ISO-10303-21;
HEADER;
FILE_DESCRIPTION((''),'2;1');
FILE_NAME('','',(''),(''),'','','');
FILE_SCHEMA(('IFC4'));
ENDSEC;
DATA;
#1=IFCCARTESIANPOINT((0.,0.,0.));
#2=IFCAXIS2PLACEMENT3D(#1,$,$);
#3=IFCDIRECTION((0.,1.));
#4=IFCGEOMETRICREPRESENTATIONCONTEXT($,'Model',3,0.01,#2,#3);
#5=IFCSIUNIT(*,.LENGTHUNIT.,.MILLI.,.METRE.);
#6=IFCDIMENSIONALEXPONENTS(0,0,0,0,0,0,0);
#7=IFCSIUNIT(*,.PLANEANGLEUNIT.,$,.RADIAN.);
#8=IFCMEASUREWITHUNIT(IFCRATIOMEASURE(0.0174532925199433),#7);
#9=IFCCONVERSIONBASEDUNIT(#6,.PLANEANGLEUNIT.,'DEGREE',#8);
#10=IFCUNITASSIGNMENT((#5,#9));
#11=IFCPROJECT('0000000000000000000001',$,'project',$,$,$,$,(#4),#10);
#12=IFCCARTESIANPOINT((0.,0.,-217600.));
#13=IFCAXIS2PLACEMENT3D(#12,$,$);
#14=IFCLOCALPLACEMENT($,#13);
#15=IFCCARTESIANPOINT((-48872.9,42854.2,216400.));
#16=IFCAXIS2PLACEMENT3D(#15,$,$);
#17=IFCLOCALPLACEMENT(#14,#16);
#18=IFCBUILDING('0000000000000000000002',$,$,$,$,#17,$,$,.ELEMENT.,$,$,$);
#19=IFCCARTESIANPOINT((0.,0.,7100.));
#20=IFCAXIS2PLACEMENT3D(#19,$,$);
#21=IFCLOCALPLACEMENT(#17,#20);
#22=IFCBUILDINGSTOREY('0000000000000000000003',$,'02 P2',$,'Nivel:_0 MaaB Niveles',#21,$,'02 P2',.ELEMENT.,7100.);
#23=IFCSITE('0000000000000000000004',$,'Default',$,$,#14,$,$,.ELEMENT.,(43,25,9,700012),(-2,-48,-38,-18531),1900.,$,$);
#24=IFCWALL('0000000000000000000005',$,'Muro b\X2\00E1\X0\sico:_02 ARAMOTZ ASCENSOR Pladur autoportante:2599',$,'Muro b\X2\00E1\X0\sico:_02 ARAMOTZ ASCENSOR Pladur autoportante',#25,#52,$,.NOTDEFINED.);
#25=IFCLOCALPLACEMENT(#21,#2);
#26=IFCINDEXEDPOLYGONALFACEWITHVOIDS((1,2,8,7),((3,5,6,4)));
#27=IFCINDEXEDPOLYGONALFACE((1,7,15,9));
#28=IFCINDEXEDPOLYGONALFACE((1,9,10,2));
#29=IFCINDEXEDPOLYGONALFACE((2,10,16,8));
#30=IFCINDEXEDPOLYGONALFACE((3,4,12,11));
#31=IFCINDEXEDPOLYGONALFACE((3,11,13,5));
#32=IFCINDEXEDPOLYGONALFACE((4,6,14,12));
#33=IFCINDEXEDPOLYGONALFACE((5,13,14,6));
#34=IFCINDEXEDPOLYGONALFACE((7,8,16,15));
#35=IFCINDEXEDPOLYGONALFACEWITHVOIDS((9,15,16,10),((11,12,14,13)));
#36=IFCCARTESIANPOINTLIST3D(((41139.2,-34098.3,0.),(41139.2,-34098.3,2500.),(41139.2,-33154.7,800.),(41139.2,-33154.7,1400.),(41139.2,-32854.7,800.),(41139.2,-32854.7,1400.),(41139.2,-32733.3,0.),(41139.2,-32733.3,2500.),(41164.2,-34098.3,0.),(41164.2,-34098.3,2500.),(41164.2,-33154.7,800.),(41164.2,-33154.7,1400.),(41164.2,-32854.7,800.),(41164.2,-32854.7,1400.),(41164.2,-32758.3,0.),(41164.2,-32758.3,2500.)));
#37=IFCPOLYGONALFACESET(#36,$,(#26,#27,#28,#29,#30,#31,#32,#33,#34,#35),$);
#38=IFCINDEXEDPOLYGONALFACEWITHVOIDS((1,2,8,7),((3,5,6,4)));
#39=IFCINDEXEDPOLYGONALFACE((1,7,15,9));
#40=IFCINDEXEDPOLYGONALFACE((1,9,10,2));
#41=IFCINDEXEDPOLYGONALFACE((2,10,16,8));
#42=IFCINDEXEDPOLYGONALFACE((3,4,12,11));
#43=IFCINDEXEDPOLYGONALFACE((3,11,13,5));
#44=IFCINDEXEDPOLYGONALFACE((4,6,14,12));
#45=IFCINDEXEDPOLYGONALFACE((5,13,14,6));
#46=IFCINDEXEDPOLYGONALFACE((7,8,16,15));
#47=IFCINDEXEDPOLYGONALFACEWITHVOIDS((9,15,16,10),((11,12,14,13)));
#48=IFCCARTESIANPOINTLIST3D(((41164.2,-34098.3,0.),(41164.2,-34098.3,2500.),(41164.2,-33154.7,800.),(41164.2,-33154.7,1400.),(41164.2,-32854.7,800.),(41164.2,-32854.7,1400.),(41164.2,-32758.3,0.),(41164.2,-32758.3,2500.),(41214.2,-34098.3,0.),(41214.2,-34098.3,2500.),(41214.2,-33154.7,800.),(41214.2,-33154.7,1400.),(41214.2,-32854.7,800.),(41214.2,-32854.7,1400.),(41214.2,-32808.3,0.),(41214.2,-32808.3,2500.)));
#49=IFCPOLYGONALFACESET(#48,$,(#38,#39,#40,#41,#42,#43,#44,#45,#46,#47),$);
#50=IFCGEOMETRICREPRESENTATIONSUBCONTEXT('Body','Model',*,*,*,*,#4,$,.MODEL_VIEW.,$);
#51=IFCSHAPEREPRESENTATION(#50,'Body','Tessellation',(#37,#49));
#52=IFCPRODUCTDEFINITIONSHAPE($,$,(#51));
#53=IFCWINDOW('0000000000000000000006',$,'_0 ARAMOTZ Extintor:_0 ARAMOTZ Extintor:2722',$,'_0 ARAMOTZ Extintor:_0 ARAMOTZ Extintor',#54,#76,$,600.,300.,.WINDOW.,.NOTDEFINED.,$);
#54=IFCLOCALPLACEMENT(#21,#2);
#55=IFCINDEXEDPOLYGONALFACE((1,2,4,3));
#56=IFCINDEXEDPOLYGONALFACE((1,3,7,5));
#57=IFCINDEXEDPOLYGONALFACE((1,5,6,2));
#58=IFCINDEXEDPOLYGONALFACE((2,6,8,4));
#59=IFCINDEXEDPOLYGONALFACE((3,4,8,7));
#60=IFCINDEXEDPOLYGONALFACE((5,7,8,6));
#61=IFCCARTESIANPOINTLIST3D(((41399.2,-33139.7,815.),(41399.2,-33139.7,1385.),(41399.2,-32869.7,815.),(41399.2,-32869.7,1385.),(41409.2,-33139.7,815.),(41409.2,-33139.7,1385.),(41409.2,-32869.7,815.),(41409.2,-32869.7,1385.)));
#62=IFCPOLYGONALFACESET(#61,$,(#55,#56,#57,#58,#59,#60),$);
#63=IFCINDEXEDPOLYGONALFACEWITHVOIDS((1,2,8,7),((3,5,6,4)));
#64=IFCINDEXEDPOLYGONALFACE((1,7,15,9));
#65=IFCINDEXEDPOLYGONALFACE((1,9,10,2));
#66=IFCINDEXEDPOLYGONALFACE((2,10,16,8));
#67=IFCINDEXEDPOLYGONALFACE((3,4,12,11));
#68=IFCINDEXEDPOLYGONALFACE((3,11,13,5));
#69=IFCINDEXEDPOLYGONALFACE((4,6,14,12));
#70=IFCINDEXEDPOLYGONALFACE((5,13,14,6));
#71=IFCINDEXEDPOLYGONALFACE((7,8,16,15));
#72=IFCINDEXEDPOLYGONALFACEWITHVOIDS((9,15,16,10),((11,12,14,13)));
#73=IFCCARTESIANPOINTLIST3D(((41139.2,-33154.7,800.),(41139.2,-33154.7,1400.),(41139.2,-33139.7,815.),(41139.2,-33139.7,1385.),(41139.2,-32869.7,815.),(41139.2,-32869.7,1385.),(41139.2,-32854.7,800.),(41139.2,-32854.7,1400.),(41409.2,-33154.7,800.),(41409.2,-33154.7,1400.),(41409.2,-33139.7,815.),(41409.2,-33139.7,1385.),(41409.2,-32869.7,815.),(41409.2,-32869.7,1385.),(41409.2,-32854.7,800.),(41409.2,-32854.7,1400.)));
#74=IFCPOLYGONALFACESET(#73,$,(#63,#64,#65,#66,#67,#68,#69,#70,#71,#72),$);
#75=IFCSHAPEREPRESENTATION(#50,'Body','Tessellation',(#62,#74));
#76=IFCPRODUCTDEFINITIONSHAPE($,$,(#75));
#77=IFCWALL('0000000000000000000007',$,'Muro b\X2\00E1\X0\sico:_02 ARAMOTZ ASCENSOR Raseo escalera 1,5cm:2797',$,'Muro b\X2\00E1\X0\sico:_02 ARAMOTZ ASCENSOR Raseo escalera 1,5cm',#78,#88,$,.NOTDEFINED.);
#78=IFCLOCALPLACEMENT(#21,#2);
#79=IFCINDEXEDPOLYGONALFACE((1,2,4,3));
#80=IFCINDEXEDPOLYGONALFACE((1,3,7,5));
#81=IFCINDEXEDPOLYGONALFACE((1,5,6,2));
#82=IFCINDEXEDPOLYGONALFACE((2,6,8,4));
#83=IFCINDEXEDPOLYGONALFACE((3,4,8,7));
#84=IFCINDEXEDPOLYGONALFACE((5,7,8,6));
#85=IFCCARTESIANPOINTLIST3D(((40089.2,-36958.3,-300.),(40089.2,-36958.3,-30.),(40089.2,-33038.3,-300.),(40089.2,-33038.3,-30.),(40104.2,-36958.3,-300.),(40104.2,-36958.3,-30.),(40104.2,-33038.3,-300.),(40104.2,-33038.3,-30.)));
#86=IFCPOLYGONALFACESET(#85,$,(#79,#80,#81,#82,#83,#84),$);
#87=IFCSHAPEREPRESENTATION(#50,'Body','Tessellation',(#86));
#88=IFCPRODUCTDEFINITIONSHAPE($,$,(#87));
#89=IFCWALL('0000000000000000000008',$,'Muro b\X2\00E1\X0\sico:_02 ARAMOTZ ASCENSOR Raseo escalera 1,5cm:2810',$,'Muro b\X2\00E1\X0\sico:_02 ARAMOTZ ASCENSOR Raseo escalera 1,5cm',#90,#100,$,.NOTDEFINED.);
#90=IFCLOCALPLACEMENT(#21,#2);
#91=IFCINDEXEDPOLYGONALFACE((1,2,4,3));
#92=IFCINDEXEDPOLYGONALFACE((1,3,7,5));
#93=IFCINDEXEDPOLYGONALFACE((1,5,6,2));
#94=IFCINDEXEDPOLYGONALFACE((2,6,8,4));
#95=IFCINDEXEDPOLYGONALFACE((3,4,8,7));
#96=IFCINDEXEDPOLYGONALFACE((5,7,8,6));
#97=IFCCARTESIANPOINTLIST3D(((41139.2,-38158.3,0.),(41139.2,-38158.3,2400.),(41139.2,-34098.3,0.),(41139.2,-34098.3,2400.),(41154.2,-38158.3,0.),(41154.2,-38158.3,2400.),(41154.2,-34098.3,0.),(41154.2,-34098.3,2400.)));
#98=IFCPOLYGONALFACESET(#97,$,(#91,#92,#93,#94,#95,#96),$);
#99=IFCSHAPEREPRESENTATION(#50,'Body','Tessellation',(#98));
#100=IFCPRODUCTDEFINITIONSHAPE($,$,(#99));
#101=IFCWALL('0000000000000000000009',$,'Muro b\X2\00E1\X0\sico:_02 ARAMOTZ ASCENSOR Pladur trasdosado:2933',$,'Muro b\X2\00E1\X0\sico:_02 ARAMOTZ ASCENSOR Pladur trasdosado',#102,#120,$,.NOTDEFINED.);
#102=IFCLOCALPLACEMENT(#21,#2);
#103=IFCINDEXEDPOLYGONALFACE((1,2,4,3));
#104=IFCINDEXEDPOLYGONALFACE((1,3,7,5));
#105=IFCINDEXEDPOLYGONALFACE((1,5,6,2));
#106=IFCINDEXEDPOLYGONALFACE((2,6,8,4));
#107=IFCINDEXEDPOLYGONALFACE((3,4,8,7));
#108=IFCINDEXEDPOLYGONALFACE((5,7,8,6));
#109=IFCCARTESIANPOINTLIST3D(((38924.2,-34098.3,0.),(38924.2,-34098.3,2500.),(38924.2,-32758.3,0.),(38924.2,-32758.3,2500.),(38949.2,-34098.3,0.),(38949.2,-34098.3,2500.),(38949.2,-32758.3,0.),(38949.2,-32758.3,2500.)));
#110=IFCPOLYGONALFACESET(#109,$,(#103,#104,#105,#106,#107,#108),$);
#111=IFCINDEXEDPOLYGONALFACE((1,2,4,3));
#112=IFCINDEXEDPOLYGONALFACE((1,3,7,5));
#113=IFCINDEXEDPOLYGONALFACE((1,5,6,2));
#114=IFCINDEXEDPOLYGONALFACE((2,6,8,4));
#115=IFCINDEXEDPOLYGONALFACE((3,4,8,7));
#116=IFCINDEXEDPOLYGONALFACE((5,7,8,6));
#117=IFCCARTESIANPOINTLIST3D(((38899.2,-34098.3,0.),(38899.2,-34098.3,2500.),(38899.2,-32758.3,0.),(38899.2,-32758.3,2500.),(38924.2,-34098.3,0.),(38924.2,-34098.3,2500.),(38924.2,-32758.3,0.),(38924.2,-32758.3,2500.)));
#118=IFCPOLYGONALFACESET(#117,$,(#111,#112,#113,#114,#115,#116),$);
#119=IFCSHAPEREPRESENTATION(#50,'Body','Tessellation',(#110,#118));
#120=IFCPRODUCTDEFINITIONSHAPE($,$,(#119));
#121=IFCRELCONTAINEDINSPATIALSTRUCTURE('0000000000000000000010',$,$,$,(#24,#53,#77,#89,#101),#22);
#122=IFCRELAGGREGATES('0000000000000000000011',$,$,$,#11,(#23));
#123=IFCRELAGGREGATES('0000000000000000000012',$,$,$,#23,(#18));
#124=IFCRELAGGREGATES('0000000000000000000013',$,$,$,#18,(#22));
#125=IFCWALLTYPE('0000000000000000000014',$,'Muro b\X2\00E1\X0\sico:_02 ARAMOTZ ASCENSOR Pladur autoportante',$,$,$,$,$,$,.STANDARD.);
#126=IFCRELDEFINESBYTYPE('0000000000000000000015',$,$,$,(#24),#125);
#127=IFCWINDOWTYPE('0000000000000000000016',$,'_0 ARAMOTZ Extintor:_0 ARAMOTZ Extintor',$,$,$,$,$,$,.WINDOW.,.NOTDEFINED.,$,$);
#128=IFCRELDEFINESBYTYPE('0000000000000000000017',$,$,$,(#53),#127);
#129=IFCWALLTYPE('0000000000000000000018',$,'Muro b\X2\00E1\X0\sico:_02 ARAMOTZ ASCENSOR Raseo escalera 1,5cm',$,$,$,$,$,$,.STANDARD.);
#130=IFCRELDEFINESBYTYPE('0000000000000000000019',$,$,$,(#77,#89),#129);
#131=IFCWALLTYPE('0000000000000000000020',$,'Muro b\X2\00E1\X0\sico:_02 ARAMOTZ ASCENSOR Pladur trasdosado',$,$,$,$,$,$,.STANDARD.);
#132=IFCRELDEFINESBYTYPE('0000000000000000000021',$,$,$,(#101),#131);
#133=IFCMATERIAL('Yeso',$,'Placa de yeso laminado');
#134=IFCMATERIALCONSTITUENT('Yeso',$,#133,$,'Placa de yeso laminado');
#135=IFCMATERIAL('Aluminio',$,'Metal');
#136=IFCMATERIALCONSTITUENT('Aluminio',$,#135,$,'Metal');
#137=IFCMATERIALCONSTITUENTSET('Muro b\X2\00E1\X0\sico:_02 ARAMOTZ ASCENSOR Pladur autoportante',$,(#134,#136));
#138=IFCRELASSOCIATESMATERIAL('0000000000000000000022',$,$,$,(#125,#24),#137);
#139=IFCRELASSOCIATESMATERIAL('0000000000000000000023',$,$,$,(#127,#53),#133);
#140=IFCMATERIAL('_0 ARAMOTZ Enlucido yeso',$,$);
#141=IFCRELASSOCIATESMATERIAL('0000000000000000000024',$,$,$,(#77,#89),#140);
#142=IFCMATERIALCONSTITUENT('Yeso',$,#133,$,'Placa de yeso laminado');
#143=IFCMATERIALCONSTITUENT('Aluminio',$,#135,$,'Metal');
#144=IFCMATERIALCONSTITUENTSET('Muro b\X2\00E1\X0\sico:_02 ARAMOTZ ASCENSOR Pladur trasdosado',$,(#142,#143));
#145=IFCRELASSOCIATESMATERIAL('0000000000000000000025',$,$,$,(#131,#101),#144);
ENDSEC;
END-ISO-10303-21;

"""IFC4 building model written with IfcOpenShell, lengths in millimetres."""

from ifc_helpers import new_model, entity, si_unit, converted_unit, direction, frame, origin, place, context, subcontext, project, spatial, indexed_curve, outline, extrude, source, transform, mapped, material, constituent, constituent_set, type_object, type_shapes, element, fill, save


model = new_model("IFC4")

# Units and contexts
model_context = context("Model", 3, precision=0.01, world=origin(), true_north=direction((0.0, 1.0)))
body_context = subcontext(model_context, "Body", "Model", "MODEL_VIEW")
ifc_project = project(units=[si_unit("LENGTHUNIT", "METRE", prefix="MILLI"), converted_unit("PLANEANGLEUNIT", "DEGREE", entity("IfcRatioMeasure", 0.0174532925199433), si_unit("PLANEANGLEUNIT", "RADIAN"), dimensions=[0, 0, 0, 0, 0, 0, 0])], contexts=[model_context])

# Site, building, storey
site_placement = place(None, frame((0.0, 0.0, -217600.0)))
site = spatial("IfcSite", under=ifc_project, at=site_placement, Name="Default", CompositionType="ELEMENT", RefLatitude=(43, 25, 9, 700012), RefLongitude=(-2, -48, -38, -18531), RefElevation=1900.0)
building_placement = place(site_placement, frame((-48872.9, 42854.2, 216400.0)))
building = spatial("IfcBuilding", under=site, at=building_placement, CompositionType="ELEMENT")
storey_placement = place(building_placement, frame((0.0, 0.0, 7100.0)))
storey = spatial("IfcBuildingStorey", under=building, at=storey_placement, Name="02 P2", ObjectType="Nivel:_0 MaaB Niveles", LongName="02 P2", CompositionType="ELEMENT", Elevation=7100.0)

# Wall, opening, window
ifc_material_1 = material(Name="Yeso", Category="Placa de yeso laminado")
ifc_constituent_1 = constituent(ifc_material_1, Name="Yeso", Category="Placa de yeso laminado")
ifc_material_2 = material(Name="Aluminio", Category="Metal")
ifc_constituent_2 = constituent(ifc_material_2, Name="Aluminio", Category="Metal")
ifc_constituent_set_1 = constituent_set(constituents=[ifc_constituent_1, ifc_constituent_2], Name="Muro básico:_02 ARAMOTZ ASCENSOR Pladur autoportante")
wall_type_1 = type_object("IfcWallType", Name="Muro básico:_02 ARAMOTZ ASCENSOR Pladur autoportante", PredefinedType="STANDARD", material=ifc_constituent_set_1)
wall_1_placement = place(storey_placement, frame((41176.7, -34098.3, 0.0), z_axis=(0.0, 0.0, 1.0), x_axis=(0.0, 1.0, 0.0)))
wall_1 = element("IfcWall", 1, at=wall_1_placement, inside=storey, type_object=wall_type_1, material=ifc_constituent_set_1, Name="Muro básico:_02 ARAMOTZ ASCENSOR Pladur autoportante:2599", ObjectType="Muro básico:_02 ARAMOTZ ASCENSOR Pladur autoportante", PredefinedType="NOTDEFINED", context=body_context, shape_type="SweptSolid", body=[
    extrude(outline(indexed_curve([(-688.8, -12.5), (676.3, -12.5), (676.3, 12.5), (-663.8, 12.5), (-688.8, -12.5)], self_intersect=False)), frame((676.3, 25.0, 0.0), z_axis=(0.0, 0.0, 1.0), x_axis=(-1.0, 0.0, 0.0)), (0.0, 0.0, 1.0), 2500.0),
    extrude(outline(indexed_curve([(-25.0, -657.5), (25.0, -657.5), (25.0, 632.5), (-25.0, 682.5), (-25.0, -657.5)], self_intersect=False)), frame((657.5, -12.5, 0.0), z_axis=(0.0, 0.0, 1.0), x_axis=(0.0, -1.0, 0.0)), (0.0, 0.0, 1.0), 2500.0),
])
opening_placement = place(wall_1_placement, frame((1243.6, 37.5, 800.0)))
opening = element("IfcOpeningElement", 2, at=opening_placement, cuts=wall_1, PredefinedType="OPENING", context=body_context, shape_type="SweptSolid", body=[
    extrude(outline(indexed_curve([(0.0, 0.0), (600.0, 0.0), (600.0, 300.0), (0.0, 300.0), (0.0, 0.0)], self_intersect=False)), frame((0.0, 0.0, 0.0), z_axis=(0.0, -1.0, 0.0), x_axis=(0.0, 0.0, 1.0)), (0.0, 0.0, 1.0), 75.0),
])
window_type = type_object("IfcWindowType", Name="_0 ARAMOTZ Extintor:_0 ARAMOTZ Extintor", PartitioningType="NOTDEFINED", PredefinedType="WINDOW", material=ifc_material_1)
shared_shape_1 = source(origin(), body_context, "Body", "SweptSolid", [
    extrude(outline(indexed_curve([(-5.0, -135.0), (5.0, -135.0), (5.0, 135.0), (-5.0, 135.0), (-5.0, -135.0)], self_intersect=False)), frame((150.0, 265.0, 15.0), z_axis=(0.0, 0.0, 1.0), x_axis=(0.0, -1.0, 0.0)), (0.0, 0.0, 1.0), 570.0),
    extrude(outline(indexed_curve([(-150.0, -300.0), (150.0, -300.0), (150.0, 300.0), (-150.0, 300.0), (-150.0, -300.0)], self_intersect=False), holes=[indexed_curve([(135.0, -285.0), (-135.0, -285.0), (-135.0, 285.0), (135.0, 285.0), (135.0, -285.0)], self_intersect=False)]), frame((150.0, 0.0, 300.0), z_axis=(0.0, 1.0, 0.0), x_axis=(1.0, 0.0, 0.0)), (0.0, 0.0, 1.0), 270.0),
])
type_shapes(window_type, [shared_shape_1])
window_placement = place(opening_placement, frame((0.0, 0.0, 0.0), z_axis=(0.0, 0.0, 1.0), x_axis=(-1.0, 0.0, 0.0)))
window = element("IfcWindow", 3, at=window_placement, inside=storey, type_object=window_type, material=ifc_material_1, Name="_0 ARAMOTZ Extintor:_0 ARAMOTZ Extintor:2722", ObjectType="_0 ARAMOTZ Extintor:_0 ARAMOTZ Extintor", OverallHeight=600.0, OverallWidth=300.0, PartitioningType="NOTDEFINED", PredefinedType="WINDOW", context=body_context, shape_type="MappedRepresentation", body=[
    mapped(shared_shape_1, transform((0.0, 0.0, 0.0), scale=1.0)),
])
fill(opening, window)

# Walls
ifc_material_3 = material(Name="_0 ARAMOTZ Enlucido yeso")
wall_type_2 = type_object("IfcWallType", Name="Muro básico:_02 ARAMOTZ ASCENSOR Raseo escalera 1,5cm", PredefinedType="STANDARD")
wall_2_placement = place(storey_placement, frame((40096.7, -36958.3, -300.0), z_axis=(0.0, 0.0, 1.0), x_axis=(0.0, 1.0, 0.0)))
element("IfcWall", 4, at=wall_2_placement, inside=storey, type_object=wall_type_2, material=ifc_material_3, Name="Muro básico:_02 ARAMOTZ ASCENSOR Raseo escalera 1,5cm:2797", ObjectType="Muro básico:_02 ARAMOTZ ASCENSOR Raseo escalera 1,5cm", PredefinedType="NOTDEFINED", context=body_context, shape_type="SweptSolid", body=[
    extrude(outline(indexed_curve([(3920.0, 7.5), (0.0, 7.5), (0.0, -7.5), (3920.0, -7.5), (3920.0, 7.5)], self_intersect=False)), origin(), (0.0, 0.0, 1.0), 270.0),
])
wall_3_placement = place(storey_placement, frame((41146.7, -38158.3, 0.0), z_axis=(0.0, 0.0, 1.0), x_axis=(0.0, 1.0, 0.0)))
element("IfcWall", 5, at=wall_3_placement, inside=storey, type_object=wall_type_2, material=ifc_material_3, Name="Muro básico:_02 ARAMOTZ ASCENSOR Raseo escalera 1,5cm:2810", ObjectType="Muro básico:_02 ARAMOTZ ASCENSOR Raseo escalera 1,5cm", PredefinedType="NOTDEFINED", context=body_context, shape_type="SweptSolid", body=[
    extrude(outline(indexed_curve([(4060.0, 7.5), (0.0, 7.5), (0.0, -7.5), (4060.0, -7.5), (4060.0, 7.5)], self_intersect=False)), origin(), (0.0, 0.0, 1.0), 2400.0),
])
ifc_constituent_3 = constituent(ifc_material_1, Name="Yeso", Category="Placa de yeso laminado")
ifc_constituent_4 = constituent(ifc_material_2, Name="Aluminio", Category="Metal")
ifc_constituent_set_2 = constituent_set(constituents=[ifc_constituent_3, ifc_constituent_4], Name="Muro básico:_02 ARAMOTZ ASCENSOR Pladur trasdosado")
wall_type_3 = type_object("IfcWallType", Name="Muro básico:_02 ARAMOTZ ASCENSOR Pladur trasdosado", PredefinedType="STANDARD", material=ifc_constituent_set_2)
wall_4_placement = place(storey_placement, frame((38924.2, -32758.3, 0.0), z_axis=(0.0, 0.0, 1.0), x_axis=(0.0, -1.0, 0.0)))
element("IfcWall", 6, at=wall_4_placement, inside=storey, type_object=wall_type_3, material=ifc_constituent_set_2, Name="Muro básico:_02 ARAMOTZ ASCENSOR Pladur trasdosado:2933", ObjectType="Muro básico:_02 ARAMOTZ ASCENSOR Pladur trasdosado", PredefinedType="NOTDEFINED", context=body_context, shape_type="SweptSolid", body=[
    extrude(outline(indexed_curve([(-670.0, -12.5), (670.0, -12.5), (670.0, 12.5), (-670.0, 12.5), (-670.0, -12.5)], self_intersect=False)), frame((670.0, 12.5, 0.0), z_axis=(0.0, 0.0, 1.0), x_axis=(-1.0, 0.0, 0.0)), (0.0, 0.0, 1.0), 2500.0),
    extrude(outline(indexed_curve([(-12.5, -670.0), (12.5, -670.0), (12.5, 670.0), (-12.5, 670.0), (-12.5, -670.0)], self_intersect=False)), frame((670.0, -12.5, 0.0), z_axis=(0.0, 0.0, 1.0), x_axis=(0.0, -1.0, 0.0)), (0.0, 0.0, 1.0), 2500.0),
])

save(model, "model.ifc")
